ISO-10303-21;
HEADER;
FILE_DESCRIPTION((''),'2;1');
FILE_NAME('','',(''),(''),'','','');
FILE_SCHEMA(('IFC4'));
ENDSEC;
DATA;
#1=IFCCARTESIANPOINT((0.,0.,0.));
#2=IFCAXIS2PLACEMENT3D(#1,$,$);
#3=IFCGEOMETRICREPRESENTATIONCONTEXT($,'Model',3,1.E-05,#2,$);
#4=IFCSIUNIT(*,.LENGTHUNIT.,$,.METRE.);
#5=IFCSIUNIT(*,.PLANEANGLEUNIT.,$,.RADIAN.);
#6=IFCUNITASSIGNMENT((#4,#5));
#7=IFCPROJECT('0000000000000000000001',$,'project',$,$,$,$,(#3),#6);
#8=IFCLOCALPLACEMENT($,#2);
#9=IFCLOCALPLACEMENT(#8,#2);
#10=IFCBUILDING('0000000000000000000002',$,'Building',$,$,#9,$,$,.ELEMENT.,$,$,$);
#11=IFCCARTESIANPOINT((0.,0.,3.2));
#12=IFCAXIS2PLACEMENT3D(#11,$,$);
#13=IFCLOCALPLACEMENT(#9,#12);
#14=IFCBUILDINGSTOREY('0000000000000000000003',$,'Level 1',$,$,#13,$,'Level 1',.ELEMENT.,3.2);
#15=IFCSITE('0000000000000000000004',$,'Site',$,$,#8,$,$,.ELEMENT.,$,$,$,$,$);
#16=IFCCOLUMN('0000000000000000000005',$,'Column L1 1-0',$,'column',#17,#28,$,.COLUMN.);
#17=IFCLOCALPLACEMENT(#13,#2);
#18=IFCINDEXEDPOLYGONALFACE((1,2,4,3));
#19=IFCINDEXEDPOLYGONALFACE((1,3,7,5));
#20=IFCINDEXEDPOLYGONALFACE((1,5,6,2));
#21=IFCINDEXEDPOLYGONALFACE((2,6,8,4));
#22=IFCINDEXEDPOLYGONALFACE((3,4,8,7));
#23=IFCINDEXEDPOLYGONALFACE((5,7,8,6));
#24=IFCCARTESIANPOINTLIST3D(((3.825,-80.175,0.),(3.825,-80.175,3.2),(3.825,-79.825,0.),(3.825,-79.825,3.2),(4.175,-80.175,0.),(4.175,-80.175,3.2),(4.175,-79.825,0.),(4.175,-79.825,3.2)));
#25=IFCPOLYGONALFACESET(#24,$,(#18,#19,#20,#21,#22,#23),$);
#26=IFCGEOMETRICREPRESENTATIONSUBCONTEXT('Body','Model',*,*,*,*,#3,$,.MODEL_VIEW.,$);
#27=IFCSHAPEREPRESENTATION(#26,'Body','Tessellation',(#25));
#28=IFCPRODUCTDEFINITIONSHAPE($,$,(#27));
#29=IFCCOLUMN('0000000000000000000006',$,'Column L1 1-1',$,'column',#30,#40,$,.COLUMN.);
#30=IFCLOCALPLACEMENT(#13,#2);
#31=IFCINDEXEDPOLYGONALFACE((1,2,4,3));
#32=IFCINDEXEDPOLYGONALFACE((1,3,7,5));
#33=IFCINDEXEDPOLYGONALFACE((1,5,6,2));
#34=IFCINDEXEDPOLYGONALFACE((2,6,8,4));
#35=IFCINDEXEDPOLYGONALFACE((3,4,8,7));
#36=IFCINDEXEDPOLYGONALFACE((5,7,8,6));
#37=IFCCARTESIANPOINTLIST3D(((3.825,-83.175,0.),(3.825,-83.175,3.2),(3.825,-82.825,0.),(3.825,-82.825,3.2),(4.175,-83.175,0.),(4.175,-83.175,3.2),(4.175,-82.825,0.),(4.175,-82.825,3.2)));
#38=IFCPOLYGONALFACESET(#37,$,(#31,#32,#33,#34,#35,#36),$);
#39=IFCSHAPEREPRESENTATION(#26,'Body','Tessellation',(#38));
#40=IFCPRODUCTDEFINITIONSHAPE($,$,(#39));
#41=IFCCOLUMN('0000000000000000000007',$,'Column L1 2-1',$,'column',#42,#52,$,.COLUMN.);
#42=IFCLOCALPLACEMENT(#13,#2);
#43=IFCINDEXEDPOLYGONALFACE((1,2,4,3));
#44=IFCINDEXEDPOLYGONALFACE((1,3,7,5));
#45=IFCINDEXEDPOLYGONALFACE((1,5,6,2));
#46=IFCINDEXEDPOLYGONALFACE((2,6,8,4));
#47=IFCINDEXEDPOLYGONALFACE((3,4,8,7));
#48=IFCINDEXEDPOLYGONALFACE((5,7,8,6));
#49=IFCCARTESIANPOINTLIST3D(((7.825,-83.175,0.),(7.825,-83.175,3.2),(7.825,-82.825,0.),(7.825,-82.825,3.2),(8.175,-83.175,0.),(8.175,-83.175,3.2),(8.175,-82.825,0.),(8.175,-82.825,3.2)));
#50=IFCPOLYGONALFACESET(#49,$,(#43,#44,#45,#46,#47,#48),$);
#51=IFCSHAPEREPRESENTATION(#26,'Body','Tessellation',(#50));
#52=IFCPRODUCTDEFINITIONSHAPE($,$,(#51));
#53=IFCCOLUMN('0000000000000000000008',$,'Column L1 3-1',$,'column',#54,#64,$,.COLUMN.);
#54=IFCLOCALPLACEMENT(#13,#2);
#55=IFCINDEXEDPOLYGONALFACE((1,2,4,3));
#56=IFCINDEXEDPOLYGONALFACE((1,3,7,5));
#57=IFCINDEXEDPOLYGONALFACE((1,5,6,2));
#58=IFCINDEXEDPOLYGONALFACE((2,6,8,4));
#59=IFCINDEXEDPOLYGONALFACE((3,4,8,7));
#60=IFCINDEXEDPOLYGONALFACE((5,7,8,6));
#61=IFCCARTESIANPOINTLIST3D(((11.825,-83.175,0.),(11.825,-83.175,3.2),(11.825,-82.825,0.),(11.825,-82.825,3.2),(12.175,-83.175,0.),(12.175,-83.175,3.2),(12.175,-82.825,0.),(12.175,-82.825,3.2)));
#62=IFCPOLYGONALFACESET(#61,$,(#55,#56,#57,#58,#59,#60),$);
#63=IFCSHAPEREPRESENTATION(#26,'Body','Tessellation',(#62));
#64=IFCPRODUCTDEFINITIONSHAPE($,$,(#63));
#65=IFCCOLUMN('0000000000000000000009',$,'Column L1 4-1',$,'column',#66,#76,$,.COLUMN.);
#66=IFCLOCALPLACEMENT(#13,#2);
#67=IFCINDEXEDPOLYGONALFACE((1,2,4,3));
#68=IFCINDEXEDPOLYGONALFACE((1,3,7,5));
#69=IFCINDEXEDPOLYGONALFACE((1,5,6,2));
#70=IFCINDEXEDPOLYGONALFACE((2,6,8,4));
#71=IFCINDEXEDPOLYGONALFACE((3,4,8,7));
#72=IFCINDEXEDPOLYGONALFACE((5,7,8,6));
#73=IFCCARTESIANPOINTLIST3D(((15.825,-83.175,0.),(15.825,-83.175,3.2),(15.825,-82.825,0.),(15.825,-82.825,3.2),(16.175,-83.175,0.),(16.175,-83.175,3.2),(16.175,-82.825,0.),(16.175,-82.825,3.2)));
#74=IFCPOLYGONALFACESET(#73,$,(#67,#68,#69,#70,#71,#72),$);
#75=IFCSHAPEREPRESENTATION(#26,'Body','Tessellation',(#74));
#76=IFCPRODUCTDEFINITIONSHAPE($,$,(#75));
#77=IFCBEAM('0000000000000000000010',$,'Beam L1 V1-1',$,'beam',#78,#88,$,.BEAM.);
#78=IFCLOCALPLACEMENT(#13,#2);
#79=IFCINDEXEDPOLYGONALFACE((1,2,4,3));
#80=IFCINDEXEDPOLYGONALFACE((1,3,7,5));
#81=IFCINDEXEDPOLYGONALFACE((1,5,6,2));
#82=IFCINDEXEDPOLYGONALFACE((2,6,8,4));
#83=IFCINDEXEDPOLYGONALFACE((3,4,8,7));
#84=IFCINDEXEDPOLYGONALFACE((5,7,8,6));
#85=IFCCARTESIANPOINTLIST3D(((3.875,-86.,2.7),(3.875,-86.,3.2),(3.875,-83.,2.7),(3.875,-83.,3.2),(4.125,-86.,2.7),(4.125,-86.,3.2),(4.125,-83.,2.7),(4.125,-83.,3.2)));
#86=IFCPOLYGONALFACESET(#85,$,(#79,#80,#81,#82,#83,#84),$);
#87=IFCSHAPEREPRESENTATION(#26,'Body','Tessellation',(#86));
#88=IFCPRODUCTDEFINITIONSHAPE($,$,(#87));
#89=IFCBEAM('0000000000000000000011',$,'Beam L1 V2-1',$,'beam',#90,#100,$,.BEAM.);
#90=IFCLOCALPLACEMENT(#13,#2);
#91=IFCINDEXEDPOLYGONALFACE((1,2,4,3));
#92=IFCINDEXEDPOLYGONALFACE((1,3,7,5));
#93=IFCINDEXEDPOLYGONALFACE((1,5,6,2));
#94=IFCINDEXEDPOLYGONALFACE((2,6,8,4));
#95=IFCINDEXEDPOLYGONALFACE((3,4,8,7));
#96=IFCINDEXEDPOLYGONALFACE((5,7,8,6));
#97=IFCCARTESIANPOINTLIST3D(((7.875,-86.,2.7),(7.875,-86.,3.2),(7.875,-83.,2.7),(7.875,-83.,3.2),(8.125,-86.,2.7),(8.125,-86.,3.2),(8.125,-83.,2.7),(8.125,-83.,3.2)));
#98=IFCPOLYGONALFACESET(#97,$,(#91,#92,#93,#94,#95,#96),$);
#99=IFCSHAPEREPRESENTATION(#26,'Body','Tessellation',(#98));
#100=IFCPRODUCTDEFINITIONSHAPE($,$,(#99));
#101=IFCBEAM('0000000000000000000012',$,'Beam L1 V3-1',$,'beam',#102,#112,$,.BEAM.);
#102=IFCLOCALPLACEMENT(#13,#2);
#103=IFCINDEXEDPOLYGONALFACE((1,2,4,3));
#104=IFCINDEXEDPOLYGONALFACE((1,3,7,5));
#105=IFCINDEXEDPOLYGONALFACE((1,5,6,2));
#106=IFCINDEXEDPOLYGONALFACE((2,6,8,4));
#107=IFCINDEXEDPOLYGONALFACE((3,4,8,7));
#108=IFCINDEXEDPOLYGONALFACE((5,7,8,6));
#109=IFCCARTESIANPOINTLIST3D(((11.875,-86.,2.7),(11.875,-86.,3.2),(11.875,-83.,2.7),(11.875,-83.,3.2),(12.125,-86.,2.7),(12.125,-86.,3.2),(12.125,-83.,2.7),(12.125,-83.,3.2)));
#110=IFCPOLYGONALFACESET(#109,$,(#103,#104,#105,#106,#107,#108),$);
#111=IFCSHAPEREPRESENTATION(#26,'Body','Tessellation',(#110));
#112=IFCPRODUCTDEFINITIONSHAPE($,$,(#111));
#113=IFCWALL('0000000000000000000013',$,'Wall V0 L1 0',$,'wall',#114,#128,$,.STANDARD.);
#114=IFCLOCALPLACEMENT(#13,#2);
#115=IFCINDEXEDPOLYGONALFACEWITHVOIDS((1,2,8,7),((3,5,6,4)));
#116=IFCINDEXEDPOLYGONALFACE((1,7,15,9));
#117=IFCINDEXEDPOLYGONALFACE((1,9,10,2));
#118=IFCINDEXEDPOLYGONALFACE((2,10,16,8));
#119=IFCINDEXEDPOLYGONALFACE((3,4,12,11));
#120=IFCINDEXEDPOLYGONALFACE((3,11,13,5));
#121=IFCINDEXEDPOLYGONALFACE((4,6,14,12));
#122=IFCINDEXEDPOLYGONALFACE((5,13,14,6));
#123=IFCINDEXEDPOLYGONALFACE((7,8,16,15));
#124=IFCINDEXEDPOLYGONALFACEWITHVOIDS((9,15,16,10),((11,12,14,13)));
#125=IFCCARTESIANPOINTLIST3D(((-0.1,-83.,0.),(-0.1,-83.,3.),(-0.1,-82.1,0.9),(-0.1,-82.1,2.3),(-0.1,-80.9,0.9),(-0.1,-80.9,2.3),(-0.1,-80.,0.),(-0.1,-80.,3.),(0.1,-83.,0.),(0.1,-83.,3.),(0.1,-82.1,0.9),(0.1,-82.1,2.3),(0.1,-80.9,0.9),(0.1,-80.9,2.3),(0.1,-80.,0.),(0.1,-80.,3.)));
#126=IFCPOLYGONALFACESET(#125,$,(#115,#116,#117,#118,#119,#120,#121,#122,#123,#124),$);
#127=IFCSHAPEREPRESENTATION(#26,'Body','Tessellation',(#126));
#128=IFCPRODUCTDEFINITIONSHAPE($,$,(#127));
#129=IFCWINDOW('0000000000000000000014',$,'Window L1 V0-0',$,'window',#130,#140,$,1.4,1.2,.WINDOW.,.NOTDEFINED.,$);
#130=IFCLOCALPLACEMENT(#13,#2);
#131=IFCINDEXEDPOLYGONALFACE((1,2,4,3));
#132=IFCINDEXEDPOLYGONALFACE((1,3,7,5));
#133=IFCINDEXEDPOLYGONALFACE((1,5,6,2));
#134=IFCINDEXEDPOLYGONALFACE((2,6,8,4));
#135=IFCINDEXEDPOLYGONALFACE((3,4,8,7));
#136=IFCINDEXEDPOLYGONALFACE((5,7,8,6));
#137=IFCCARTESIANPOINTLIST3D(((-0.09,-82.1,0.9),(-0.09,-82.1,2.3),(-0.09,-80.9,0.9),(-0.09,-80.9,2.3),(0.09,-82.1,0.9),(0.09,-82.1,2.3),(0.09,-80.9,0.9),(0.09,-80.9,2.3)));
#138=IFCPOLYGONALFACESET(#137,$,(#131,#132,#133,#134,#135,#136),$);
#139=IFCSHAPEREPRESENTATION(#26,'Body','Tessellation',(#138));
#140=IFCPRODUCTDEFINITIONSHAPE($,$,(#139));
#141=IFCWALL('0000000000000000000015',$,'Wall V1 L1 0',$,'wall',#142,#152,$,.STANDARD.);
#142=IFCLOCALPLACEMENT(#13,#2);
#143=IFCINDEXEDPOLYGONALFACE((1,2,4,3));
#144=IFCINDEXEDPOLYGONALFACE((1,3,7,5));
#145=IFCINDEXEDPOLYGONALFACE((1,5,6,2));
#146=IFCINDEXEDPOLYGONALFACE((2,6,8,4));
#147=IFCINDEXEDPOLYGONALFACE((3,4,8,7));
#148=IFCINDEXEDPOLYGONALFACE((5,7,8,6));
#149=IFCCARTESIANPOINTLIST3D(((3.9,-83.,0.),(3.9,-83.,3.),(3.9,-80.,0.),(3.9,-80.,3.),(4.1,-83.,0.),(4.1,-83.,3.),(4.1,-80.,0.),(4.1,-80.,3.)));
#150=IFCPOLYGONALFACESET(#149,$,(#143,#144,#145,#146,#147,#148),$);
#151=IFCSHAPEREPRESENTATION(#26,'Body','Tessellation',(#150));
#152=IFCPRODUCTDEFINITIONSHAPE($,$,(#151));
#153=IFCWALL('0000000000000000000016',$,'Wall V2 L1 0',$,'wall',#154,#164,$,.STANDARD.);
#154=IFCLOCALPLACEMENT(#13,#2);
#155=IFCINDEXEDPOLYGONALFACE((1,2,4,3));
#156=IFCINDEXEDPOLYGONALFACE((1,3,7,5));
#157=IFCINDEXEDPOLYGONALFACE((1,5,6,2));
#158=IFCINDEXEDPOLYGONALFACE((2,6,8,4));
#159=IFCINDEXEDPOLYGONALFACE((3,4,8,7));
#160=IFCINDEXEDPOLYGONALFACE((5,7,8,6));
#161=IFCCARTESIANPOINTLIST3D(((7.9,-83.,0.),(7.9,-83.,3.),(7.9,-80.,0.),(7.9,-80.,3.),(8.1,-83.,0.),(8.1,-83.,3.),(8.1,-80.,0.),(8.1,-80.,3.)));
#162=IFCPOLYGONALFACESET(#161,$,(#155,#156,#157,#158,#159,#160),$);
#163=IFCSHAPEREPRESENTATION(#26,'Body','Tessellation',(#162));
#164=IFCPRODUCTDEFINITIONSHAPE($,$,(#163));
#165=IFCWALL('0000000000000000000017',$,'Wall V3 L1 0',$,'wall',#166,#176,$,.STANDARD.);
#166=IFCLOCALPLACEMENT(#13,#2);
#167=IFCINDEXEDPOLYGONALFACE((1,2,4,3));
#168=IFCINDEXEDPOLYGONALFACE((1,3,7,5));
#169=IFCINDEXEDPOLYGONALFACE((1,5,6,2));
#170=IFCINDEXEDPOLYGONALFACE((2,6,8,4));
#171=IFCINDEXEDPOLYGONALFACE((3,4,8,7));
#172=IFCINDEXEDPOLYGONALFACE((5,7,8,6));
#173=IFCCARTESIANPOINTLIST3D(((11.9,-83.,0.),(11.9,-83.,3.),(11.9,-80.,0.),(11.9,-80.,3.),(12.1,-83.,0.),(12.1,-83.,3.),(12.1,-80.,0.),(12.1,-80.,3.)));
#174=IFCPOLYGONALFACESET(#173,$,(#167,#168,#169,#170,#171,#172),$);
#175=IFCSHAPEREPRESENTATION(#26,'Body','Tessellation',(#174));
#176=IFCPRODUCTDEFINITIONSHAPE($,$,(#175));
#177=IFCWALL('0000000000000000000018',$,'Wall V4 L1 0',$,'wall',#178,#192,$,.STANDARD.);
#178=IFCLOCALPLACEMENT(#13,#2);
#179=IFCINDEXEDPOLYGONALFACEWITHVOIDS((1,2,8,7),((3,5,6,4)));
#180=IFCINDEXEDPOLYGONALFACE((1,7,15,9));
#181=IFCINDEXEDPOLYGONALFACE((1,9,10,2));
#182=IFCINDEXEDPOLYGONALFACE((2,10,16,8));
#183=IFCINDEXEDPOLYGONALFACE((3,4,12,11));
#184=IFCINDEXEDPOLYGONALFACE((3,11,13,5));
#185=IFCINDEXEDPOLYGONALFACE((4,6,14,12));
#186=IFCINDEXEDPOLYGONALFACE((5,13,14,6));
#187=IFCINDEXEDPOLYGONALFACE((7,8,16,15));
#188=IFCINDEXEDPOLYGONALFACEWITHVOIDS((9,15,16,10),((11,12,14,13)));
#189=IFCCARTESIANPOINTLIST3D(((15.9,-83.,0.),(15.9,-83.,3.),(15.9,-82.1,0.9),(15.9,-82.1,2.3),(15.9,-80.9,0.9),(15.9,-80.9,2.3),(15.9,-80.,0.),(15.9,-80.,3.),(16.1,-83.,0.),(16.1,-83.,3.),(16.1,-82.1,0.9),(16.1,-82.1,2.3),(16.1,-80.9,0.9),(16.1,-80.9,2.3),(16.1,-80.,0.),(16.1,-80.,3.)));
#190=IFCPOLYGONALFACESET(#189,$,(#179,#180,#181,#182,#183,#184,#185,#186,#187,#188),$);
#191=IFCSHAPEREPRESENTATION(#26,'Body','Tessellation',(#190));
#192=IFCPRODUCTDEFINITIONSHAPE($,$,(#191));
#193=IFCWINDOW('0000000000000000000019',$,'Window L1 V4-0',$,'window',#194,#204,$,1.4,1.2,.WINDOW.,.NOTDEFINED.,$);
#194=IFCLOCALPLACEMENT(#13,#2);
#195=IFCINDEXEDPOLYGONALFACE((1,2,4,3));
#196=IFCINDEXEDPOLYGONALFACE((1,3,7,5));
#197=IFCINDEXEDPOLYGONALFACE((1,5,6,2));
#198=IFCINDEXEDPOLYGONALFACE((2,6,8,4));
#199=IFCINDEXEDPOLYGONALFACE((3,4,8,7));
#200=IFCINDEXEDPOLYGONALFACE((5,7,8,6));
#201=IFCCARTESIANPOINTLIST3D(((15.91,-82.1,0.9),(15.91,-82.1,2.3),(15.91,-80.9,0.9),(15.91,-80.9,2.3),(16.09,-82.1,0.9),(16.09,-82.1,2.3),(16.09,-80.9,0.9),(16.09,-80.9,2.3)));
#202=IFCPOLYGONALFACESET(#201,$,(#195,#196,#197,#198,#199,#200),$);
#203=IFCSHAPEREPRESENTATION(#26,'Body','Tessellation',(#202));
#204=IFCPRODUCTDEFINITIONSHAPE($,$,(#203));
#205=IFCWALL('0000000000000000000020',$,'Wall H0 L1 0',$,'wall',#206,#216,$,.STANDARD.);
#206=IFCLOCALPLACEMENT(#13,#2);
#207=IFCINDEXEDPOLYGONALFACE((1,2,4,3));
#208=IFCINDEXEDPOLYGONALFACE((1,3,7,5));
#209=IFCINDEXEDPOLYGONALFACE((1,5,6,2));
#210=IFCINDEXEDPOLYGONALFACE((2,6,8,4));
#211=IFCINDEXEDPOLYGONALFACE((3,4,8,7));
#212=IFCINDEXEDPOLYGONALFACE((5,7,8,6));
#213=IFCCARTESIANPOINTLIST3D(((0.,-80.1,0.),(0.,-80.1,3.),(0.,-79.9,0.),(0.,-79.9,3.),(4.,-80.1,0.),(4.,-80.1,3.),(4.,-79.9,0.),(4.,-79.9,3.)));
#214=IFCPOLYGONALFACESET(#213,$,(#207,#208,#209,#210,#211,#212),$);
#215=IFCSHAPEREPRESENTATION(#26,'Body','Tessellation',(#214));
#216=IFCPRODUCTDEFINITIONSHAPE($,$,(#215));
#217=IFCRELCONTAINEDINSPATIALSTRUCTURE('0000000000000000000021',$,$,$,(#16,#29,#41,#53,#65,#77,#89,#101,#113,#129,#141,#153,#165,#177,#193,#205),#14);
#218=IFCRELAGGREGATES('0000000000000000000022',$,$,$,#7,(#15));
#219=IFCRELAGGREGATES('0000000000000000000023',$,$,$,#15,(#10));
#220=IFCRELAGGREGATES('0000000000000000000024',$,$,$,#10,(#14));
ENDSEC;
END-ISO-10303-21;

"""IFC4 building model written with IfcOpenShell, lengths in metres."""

from ifc_helpers import new_model, si_unit, frame, frame_2d, origin, origin_2d, place, context, subcontext, project, spatial, rectangle, extrude, element, fill, save


model = new_model("IFC4")

# Units and contexts
model_context = context("Model", 3, precision=1e-05, world=origin())
body_context = subcontext(model_context, "Body", "Model", "MODEL_VIEW")
ifc_project = project(units=[si_unit("LENGTHUNIT", "METRE"), si_unit("PLANEANGLEUNIT", "RADIAN")], contexts=[model_context])

# Site, building, storey
site_placement = place(None, origin())
site = spatial("IfcSite", under=ifc_project, at=site_placement, Name="Site", CompositionType="ELEMENT")
building_placement = place(site_placement, origin())
building = spatial("IfcBuilding", under=site, at=building_placement, Name="Building", CompositionType="ELEMENT")
storey_placement = place(building_placement, frame((0.0, 0.0, 3.2)))
storey = spatial("IfcBuildingStorey", under=building, at=storey_placement, Name="Level 1", LongName="Level 1", CompositionType="ELEMENT", Elevation=3.2)

# Columns
for number, where, name in (
    (1, (4.0, -80.0, 0.0), "Column L1 1-0"),
    (2, (4.0, -83.0, 0.0), "Column L1 1-1"),
    (3, (8.0, -83.0, 0.0), "Column L1 2-1"),
    (4, (12.0, -83.0, 0.0), "Column L1 3-1"),
    (5, (16.0, -83.0, 0.0), "Column L1 4-1"),
):
    element("IfcColumn", number, at=place(storey_placement, frame(where)), inside=storey, Name=name, ObjectType="column", PredefinedType="COLUMN", context=body_context, shape_type="SweptSolid", body=[
        extrude(rectangle(XDim=0.35, YDim=0.35, at=origin_2d()), origin(), (0.0, 0.0, 1.0), 3.2),
    ])

# Beams
for number, where, z_axis, x_axis, name in (
    (6, (4.0, -83.0, 2.95), (0.0, -1.0, 0.0), (0.0, 0.0, 1.0), "Beam L1 V1-1"),
    (7, (8.0, -83.0, 2.95), (0.0, -1.0, 0.0), (0.0, 0.0, 1.0), "Beam L1 V2-1"),
    (8, (12.0, -83.0, 2.95), (0.0, -1.0, 0.0), (0.0, 0.0, 1.0), "Beam L1 V3-1"),
):
    element("IfcBeam", number, at=place(storey_placement, frame(where, z_axis=z_axis, x_axis=x_axis)), inside=storey, Name=name, ObjectType="beam", PredefinedType="BEAM", context=body_context, shape_type="SweptSolid", body=[
        extrude(rectangle(XDim=0.5, YDim=0.25, at=origin_2d()), origin(), (0.0, 0.0, 1.0), 3.0),
    ])

# Wall, opening, window
wall_1_placement = place(storey_placement, frame((0.0, -80.0, 0.0), z_axis=(0.0, 0.0, 1.0), x_axis=(0.0, -1.0, 0.0)))
wall_1 = element("IfcWall", 9, at=wall_1_placement, inside=storey, Name="Wall V0 L1 0", ObjectType="wall", PredefinedType="STANDARD", context=body_context, shape_type="SweptSolid", body=[
    extrude(rectangle(XDim=3.0, YDim=0.2, at=frame_2d((1.5, 0.0))), origin(), (0.0, 0.0, 1.0), 3.0),
])
opening_1_placement = place(storey_placement, frame((0.0, -81.5, 0.9), z_axis=(0.0, 0.0, 1.0), x_axis=(0.0, -1.0, 0.0)))
opening_1 = element("IfcOpeningElement", 10, at=opening_1_placement, cuts=wall_1, ObjectType="Opening", PredefinedType="OPENING", context=body_context, shape_type="SweptSolid", body=[
    extrude(rectangle(XDim=1.2, YDim=0.22, at=origin_2d()), origin(), (0.0, 0.0, 1.0), 1.4),
])
window_1_placement = place(storey_placement, frame((0.0, -81.5, 0.9), z_axis=(0.0, 0.0, 1.0), x_axis=(0.0, -1.0, 0.0)))
window_1 = element("IfcWindow", 11, at=window_1_placement, inside=storey, Name="Window L1 V0-0", ObjectType="window", OverallHeight=1.4, OverallWidth=1.2, PartitioningType="NOTDEFINED", PredefinedType="WINDOW", context=body_context, shape_type="SweptSolid", body=[
    extrude(rectangle(XDim=1.2, YDim=0.18, at=origin_2d()), origin(), (0.0, 0.0, 1.0), 1.4),
])
fill(opening_1, window_1)

# Walls
for number, where, z_axis, x_axis, name in (
    (12, (4.0, -80.0, 0.0), (0.0, 0.0, 1.0), (0.0, -1.0, 0.0), "Wall V1 L1 0"),
    (13, (8.0, -80.0, 0.0), (0.0, 0.0, 1.0), (0.0, -1.0, 0.0), "Wall V2 L1 0"),
    (14, (12.0, -80.0, 0.0), (0.0, 0.0, 1.0), (0.0, -1.0, 0.0), "Wall V3 L1 0"),
):
    element("IfcWall", number, at=place(storey_placement, frame(where, z_axis=z_axis, x_axis=x_axis)), inside=storey, Name=name, ObjectType="wall", PredefinedType="STANDARD", context=body_context, shape_type="SweptSolid", body=[
        extrude(rectangle(XDim=3.0, YDim=0.2, at=frame_2d((1.5, 0.0))), origin(), (0.0, 0.0, 1.0), 3.0),
    ])

# Wall, opening, window
wall_2_placement = place(storey_placement, frame((16.0, -80.0, 0.0), z_axis=(0.0, 0.0, 1.0), x_axis=(0.0, -1.0, 0.0)))
wall_2 = element("IfcWall", 15, at=wall_2_placement, inside=storey, Name="Wall V4 L1 0", ObjectType="wall", PredefinedType="STANDARD", context=body_context, shape_type="SweptSolid", body=[
    extrude(rectangle(XDim=3.0, YDim=0.2, at=frame_2d((1.5, 0.0))), origin(), (0.0, 0.0, 1.0), 3.0),
])
opening_2_placement = place(storey_placement, frame((16.0, -81.5, 0.9), z_axis=(0.0, 0.0, 1.0), x_axis=(0.0, -1.0, 0.0)))
opening_2 = element("IfcOpeningElement", 16, at=opening_2_placement, cuts=wall_2, ObjectType="Opening", PredefinedType="OPENING", context=body_context, shape_type="SweptSolid", body=[
    extrude(rectangle(XDim=1.2, YDim=0.22, at=origin_2d()), origin(), (0.0, 0.0, 1.0), 1.4),
])
window_2_placement = place(storey_placement, frame((16.0, -81.5, 0.9), z_axis=(0.0, 0.0, 1.0), x_axis=(0.0, -1.0, 0.0)))
window_2 = element("IfcWindow", 17, at=window_2_placement, inside=storey, Name="Window L1 V4-0", ObjectType="window", OverallHeight=1.4, OverallWidth=1.2, PartitioningType="NOTDEFINED", PredefinedType="WINDOW", context=body_context, shape_type="SweptSolid", body=[
    extrude(rectangle(XDim=1.2, YDim=0.18, at=origin_2d()), origin(), (0.0, 0.0, 1.0), 1.4),
])
fill(opening_2, window_2)

# Wall
wall_3_placement = place(storey_placement, frame((0.0, -80.0, 0.0), z_axis=(0.0, 0.0, 1.0), x_axis=(1.0, 0.0, 0.0)))
element("IfcWall", 18, at=wall_3_placement, inside=storey, Name="Wall H0 L1 0", ObjectType="wall", PredefinedType="STANDARD", context=body_context, shape_type="SweptSolid", body=[
    extrude(rectangle(XDim=4.0, YDim=0.2, at=frame_2d((2.0, 0.0))), origin(), (0.0, 0.0, 1.0), 3.0),
])

save(model, "model.ifc")
